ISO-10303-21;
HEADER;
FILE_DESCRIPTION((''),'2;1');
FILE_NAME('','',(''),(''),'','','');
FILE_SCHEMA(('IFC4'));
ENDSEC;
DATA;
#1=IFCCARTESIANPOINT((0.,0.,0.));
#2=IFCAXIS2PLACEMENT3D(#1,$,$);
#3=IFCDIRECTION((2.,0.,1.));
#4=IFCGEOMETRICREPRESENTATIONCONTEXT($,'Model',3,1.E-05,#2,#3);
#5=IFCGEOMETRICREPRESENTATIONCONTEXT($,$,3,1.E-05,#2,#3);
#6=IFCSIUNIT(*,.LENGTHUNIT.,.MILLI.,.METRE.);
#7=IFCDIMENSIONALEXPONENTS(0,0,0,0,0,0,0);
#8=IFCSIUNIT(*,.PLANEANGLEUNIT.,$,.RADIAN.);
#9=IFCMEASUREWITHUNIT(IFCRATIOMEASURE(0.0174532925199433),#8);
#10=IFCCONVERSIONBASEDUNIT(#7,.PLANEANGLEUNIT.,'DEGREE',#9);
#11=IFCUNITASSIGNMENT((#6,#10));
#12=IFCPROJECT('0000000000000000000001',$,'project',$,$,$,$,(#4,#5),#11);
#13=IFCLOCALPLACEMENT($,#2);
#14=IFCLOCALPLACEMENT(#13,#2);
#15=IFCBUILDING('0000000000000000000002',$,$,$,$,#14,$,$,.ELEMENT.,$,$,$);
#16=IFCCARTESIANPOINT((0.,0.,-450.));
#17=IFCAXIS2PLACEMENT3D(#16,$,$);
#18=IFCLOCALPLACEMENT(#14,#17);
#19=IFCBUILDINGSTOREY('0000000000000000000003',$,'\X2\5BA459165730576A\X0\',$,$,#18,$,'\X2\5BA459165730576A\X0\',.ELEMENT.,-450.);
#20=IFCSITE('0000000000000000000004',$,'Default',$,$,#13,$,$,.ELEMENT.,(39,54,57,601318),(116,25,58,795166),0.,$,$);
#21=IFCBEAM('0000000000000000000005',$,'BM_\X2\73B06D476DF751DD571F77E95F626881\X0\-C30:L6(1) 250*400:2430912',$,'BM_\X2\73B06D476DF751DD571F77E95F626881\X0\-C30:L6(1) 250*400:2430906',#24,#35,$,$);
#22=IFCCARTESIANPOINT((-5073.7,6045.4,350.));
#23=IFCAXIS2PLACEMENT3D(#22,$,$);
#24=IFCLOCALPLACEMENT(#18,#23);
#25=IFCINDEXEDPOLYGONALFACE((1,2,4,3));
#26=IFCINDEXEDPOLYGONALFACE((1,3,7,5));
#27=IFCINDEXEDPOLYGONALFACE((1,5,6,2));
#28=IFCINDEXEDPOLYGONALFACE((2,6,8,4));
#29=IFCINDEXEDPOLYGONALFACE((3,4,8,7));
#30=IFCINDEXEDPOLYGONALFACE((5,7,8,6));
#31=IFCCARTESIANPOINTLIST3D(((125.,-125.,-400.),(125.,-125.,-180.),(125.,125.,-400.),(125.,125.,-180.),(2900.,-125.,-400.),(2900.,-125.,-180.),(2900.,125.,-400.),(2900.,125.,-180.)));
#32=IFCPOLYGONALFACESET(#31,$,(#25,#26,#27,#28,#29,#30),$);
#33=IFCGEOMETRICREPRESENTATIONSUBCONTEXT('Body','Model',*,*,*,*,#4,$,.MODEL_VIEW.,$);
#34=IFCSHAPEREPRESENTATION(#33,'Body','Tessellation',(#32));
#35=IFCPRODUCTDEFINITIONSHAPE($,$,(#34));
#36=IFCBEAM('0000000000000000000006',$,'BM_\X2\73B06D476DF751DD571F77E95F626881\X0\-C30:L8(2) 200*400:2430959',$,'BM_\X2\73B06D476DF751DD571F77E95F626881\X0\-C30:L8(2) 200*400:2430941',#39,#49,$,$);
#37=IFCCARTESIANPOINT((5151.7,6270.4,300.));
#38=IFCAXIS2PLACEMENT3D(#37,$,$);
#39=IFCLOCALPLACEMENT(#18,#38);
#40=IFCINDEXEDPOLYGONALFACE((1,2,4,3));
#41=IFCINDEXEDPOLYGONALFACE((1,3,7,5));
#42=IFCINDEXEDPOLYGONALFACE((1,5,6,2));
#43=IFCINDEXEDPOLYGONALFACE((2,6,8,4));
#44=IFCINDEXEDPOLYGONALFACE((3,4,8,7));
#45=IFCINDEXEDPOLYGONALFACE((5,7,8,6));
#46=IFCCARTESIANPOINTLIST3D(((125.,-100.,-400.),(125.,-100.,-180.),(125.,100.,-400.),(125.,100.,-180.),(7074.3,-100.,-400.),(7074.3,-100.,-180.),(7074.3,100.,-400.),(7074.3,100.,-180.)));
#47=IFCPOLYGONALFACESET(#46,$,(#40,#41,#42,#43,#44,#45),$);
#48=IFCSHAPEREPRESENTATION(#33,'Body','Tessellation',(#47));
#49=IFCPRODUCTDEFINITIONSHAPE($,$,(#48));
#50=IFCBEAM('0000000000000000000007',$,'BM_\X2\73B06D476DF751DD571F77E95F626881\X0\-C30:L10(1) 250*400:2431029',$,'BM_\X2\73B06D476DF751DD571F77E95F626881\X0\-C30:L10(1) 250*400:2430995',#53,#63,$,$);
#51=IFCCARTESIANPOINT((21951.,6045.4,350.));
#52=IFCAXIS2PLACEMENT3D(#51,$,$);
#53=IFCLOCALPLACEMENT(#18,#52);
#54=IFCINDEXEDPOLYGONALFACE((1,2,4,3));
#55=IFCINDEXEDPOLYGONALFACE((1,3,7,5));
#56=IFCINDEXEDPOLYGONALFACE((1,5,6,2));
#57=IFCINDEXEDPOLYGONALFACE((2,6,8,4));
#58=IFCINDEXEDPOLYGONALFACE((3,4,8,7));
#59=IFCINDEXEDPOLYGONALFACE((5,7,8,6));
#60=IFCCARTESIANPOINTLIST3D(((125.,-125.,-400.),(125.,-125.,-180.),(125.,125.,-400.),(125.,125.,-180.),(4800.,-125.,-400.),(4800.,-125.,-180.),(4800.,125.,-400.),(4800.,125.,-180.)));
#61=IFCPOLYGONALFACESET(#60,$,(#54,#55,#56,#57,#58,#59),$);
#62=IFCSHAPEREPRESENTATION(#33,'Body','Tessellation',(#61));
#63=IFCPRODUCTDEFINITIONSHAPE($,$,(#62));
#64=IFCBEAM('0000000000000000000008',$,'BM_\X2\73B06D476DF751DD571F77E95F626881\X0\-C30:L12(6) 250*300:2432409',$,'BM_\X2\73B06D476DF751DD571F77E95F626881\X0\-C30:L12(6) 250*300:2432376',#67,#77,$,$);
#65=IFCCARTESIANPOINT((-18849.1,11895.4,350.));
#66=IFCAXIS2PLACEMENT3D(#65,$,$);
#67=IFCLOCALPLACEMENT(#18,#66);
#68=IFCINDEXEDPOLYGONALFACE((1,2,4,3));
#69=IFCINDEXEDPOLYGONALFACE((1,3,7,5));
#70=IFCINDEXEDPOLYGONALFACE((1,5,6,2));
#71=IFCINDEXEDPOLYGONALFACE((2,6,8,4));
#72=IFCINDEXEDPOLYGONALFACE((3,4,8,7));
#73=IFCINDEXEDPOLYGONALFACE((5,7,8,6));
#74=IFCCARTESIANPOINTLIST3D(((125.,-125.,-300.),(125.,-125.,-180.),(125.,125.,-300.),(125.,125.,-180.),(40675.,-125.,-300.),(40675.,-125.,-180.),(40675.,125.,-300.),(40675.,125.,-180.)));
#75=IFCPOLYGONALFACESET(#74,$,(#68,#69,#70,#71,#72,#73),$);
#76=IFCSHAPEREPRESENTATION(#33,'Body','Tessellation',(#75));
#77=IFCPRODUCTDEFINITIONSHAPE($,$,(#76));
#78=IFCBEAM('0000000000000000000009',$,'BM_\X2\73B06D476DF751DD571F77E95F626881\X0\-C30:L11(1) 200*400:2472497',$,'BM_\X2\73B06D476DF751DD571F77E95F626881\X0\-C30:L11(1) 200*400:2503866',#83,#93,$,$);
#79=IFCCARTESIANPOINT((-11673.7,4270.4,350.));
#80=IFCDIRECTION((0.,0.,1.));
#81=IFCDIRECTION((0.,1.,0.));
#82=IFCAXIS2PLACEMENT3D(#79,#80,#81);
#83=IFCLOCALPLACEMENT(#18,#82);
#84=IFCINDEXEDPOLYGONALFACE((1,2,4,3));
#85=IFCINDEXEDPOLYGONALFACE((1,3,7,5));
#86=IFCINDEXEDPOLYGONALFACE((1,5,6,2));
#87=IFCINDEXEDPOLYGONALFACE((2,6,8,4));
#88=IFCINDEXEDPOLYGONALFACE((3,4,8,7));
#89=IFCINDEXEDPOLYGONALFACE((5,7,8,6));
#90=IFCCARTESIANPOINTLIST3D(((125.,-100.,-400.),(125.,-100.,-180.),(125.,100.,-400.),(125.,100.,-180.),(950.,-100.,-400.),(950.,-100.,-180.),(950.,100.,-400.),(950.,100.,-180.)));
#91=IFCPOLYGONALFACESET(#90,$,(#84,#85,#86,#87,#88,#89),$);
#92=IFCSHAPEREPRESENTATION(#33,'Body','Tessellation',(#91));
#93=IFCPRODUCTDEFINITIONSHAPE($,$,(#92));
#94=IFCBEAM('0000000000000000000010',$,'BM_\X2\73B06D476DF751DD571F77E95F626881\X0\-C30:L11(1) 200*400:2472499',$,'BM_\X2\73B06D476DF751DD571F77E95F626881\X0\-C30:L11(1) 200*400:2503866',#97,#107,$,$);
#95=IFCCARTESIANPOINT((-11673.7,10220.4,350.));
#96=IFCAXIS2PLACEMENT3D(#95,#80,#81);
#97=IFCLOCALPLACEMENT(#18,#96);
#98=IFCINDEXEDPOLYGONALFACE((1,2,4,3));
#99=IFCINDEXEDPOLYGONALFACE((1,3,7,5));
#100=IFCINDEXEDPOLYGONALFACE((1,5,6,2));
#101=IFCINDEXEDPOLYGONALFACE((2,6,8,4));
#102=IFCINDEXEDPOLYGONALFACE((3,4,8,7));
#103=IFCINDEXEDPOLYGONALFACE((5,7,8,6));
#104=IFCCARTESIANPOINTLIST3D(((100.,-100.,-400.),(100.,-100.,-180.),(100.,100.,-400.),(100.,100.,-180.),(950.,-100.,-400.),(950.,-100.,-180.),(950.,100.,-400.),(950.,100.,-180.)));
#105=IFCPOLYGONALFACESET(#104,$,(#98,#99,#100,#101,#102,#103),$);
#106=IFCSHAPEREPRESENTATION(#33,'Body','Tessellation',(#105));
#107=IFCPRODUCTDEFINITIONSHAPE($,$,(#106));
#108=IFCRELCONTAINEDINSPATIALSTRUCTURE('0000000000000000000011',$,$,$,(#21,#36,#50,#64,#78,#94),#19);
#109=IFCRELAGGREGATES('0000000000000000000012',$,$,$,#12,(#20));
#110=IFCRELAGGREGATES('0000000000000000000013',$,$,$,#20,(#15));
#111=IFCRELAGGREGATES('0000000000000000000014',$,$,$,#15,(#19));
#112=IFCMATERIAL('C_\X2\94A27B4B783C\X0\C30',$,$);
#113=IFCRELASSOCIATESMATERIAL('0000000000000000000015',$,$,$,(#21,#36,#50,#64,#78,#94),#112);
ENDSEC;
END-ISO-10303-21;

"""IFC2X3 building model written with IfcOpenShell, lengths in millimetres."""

from ifc_helpers import new_model, entity, si_unit, converted_unit, direction, frame, frame_2d, origin, place, context, subcontext, project, spatial, rectangle, extrude, material, element, save


model = new_model("IFC2X3")

# Units and contexts
model_context = context("Model", 3, precision=1e-05, world=origin(), true_north=direction((2.0, 0.0, 1.0)))
context_of_model = context(None, 3, precision=1e-05, world=origin(), true_north=direction((2.0, 0.0, 1.0)))
body_context = subcontext(model_context, "Body", "Model", "MODEL_VIEW")
ifc_project = project(units=[si_unit("LENGTHUNIT", "METRE", prefix="MILLI"), converted_unit("PLANEANGLEUNIT", "DEGREE", entity("IfcRatioMeasure", 0.0174532925199433), si_unit("PLANEANGLEUNIT", "RADIAN"), dimensions=[0, 0, 0, 0, 0, 0, 0])], contexts=[model_context, context_of_model])

# Site, building, storey
site_placement = place(None, origin())
site = spatial("IfcSite", under=ifc_project, at=site_placement, Name="Default", CompositionType="ELEMENT", RefLatitude=(39, 54, 57, 601318), RefLongitude=(116, 25, 58, 795166), RefElevation=0.0)
building_placement = place(site_placement, origin())
building = spatial("IfcBuilding", under=site, at=building_placement, CompositionType="ELEMENT")
storey_placement = place(building_placement, frame((0.0, 0.0, -450.0)))
storey = spatial("IfcBuildingStorey", under=building, at=storey_placement, Name="室外地坪", LongName="室外地坪", CompositionType="ELEMENT", Elevation=-450.0)

# Beams
ifc_material = material(Name="C_钢筋砼C30")
beam_1_placement = place(storey_placement, frame((-5073.7, 6045.4, 350.0)))
element("IfcBeam", 1, at=beam_1_placement, inside=storey, material=ifc_material, Name="BM_现浇混凝土矩形梁-C30:L6(1) 250*400:2430912", ObjectType="BM_现浇混凝土矩形梁-C30:L6(1) 250*400:2430906", context=body_context, shape_type="SweptSolid", body=[
    extrude(rectangle(XDim=220.0, YDim=250.0, at=frame_2d((0.0, 0.0), x_axis=(1.0, 0.0))), frame((125.0, 0.0, -290.0), z_axis=(1.0, 0.0, 0.0), x_axis=(0.0, 0.0, -1.0)), (0.0, 0.0, 1.0), 2775.0),
])
beam_2_placement = place(storey_placement, frame((5151.7, 6270.4, 300.0)))
element("IfcBeam", 2, at=beam_2_placement, inside=storey, material=ifc_material, Name="BM_现浇混凝土矩形梁-C30:L8(2) 200*400:2430959", ObjectType="BM_现浇混凝土矩形梁-C30:L8(2) 200*400:2430941", context=body_context, shape_type="SweptSolid", body=[
    extrude(rectangle(XDim=220.0, YDim=200.0, at=frame_2d((0.0, 0.0), x_axis=(1.0, 0.0))), frame((125.0, 0.0, -290.0), z_axis=(1.0, 0.0, 0.0), x_axis=(0.0, 0.0, -1.0)), (0.0, 0.0, 1.0), 6949.3),
])
beam_3_placement = place(storey_placement, frame((21951.0, 6045.4, 350.0)))
element("IfcBeam", 3, at=beam_3_placement, inside=storey, material=ifc_material, Name="BM_现浇混凝土矩形梁-C30:L10(1) 250*400:2431029", ObjectType="BM_现浇混凝土矩形梁-C30:L10(1) 250*400:2430995", context=body_context, shape_type="SweptSolid", body=[
    extrude(rectangle(XDim=220.0, YDim=250.0, at=frame_2d((0.0, 0.0), x_axis=(1.0, 0.0))), frame((125.0, 0.0, -290.0), z_axis=(1.0, 0.0, 0.0), x_axis=(0.0, 0.0, -1.0)), (0.0, 0.0, 1.0), 4675.0),
])
beam_4_placement = place(storey_placement, frame((-18849.1, 11895.4, 350.0)))
element("IfcBeam", 4, at=beam_4_placement, inside=storey, material=ifc_material, Name="BM_现浇混凝土矩形梁-C30:L12(6) 250*300:2432409", ObjectType="BM_现浇混凝土矩形梁-C30:L12(6) 250*300:2432376", context=body_context, shape_type="SweptSolid", body=[
    extrude(rectangle(XDim=120.0, YDim=250.0, at=frame_2d((0.0, 0.0), x_axis=(1.0, 0.0))), frame((125.0, 0.0, -240.0), z_axis=(1.0, 0.0, 0.0), x_axis=(0.0, 0.0, -1.0)), (0.0, 0.0, 1.0), 40550.0),
])
beam_5_placement = place(storey_placement, frame((-11673.7, 4270.4, 350.0), z_axis=(0.0, 0.0, 1.0), x_axis=(0.0, 1.0, 0.0)))
element("IfcBeam", 5, at=beam_5_placement, inside=storey, material=ifc_material, Name="BM_现浇混凝土矩形梁-C30:L11(1) 200*400:2472497", ObjectType="BM_现浇混凝土矩形梁-C30:L11(1) 200*400:2503866", context=body_context, shape_type="SweptSolid", body=[
    extrude(rectangle(XDim=220.0, YDim=200.0, at=frame_2d((0.0, 0.0), x_axis=(1.0, 0.0))), frame((125.0, 0.0, -290.0), z_axis=(1.0, 0.0, 0.0), x_axis=(0.0, 0.0, -1.0)), (0.0, 0.0, 1.0), 825.0),
])
beam_6_placement = place(storey_placement, frame((-11673.7, 10220.4, 350.0), z_axis=(0.0, 0.0, 1.0), x_axis=(0.0, 1.0, 0.0)))
element("IfcBeam", 6, at=beam_6_placement, inside=storey, material=ifc_material, Name="BM_现浇混凝土矩形梁-C30:L11(1) 200*400:2472499", ObjectType="BM_现浇混凝土矩形梁-C30:L11(1) 200*400:2503866", context=body_context, shape_type="SweptSolid", body=[
    extrude(rectangle(XDim=220.0, YDim=200.0, at=frame_2d((0.0, 0.0), x_axis=(1.0, 0.0))), frame((100.0, 0.0, -290.0), z_axis=(1.0, 0.0, 0.0), x_axis=(0.0, 0.0, -1.0)), (0.0, 0.0, 1.0), 850.0),
])

save(model, "model.ifc")
